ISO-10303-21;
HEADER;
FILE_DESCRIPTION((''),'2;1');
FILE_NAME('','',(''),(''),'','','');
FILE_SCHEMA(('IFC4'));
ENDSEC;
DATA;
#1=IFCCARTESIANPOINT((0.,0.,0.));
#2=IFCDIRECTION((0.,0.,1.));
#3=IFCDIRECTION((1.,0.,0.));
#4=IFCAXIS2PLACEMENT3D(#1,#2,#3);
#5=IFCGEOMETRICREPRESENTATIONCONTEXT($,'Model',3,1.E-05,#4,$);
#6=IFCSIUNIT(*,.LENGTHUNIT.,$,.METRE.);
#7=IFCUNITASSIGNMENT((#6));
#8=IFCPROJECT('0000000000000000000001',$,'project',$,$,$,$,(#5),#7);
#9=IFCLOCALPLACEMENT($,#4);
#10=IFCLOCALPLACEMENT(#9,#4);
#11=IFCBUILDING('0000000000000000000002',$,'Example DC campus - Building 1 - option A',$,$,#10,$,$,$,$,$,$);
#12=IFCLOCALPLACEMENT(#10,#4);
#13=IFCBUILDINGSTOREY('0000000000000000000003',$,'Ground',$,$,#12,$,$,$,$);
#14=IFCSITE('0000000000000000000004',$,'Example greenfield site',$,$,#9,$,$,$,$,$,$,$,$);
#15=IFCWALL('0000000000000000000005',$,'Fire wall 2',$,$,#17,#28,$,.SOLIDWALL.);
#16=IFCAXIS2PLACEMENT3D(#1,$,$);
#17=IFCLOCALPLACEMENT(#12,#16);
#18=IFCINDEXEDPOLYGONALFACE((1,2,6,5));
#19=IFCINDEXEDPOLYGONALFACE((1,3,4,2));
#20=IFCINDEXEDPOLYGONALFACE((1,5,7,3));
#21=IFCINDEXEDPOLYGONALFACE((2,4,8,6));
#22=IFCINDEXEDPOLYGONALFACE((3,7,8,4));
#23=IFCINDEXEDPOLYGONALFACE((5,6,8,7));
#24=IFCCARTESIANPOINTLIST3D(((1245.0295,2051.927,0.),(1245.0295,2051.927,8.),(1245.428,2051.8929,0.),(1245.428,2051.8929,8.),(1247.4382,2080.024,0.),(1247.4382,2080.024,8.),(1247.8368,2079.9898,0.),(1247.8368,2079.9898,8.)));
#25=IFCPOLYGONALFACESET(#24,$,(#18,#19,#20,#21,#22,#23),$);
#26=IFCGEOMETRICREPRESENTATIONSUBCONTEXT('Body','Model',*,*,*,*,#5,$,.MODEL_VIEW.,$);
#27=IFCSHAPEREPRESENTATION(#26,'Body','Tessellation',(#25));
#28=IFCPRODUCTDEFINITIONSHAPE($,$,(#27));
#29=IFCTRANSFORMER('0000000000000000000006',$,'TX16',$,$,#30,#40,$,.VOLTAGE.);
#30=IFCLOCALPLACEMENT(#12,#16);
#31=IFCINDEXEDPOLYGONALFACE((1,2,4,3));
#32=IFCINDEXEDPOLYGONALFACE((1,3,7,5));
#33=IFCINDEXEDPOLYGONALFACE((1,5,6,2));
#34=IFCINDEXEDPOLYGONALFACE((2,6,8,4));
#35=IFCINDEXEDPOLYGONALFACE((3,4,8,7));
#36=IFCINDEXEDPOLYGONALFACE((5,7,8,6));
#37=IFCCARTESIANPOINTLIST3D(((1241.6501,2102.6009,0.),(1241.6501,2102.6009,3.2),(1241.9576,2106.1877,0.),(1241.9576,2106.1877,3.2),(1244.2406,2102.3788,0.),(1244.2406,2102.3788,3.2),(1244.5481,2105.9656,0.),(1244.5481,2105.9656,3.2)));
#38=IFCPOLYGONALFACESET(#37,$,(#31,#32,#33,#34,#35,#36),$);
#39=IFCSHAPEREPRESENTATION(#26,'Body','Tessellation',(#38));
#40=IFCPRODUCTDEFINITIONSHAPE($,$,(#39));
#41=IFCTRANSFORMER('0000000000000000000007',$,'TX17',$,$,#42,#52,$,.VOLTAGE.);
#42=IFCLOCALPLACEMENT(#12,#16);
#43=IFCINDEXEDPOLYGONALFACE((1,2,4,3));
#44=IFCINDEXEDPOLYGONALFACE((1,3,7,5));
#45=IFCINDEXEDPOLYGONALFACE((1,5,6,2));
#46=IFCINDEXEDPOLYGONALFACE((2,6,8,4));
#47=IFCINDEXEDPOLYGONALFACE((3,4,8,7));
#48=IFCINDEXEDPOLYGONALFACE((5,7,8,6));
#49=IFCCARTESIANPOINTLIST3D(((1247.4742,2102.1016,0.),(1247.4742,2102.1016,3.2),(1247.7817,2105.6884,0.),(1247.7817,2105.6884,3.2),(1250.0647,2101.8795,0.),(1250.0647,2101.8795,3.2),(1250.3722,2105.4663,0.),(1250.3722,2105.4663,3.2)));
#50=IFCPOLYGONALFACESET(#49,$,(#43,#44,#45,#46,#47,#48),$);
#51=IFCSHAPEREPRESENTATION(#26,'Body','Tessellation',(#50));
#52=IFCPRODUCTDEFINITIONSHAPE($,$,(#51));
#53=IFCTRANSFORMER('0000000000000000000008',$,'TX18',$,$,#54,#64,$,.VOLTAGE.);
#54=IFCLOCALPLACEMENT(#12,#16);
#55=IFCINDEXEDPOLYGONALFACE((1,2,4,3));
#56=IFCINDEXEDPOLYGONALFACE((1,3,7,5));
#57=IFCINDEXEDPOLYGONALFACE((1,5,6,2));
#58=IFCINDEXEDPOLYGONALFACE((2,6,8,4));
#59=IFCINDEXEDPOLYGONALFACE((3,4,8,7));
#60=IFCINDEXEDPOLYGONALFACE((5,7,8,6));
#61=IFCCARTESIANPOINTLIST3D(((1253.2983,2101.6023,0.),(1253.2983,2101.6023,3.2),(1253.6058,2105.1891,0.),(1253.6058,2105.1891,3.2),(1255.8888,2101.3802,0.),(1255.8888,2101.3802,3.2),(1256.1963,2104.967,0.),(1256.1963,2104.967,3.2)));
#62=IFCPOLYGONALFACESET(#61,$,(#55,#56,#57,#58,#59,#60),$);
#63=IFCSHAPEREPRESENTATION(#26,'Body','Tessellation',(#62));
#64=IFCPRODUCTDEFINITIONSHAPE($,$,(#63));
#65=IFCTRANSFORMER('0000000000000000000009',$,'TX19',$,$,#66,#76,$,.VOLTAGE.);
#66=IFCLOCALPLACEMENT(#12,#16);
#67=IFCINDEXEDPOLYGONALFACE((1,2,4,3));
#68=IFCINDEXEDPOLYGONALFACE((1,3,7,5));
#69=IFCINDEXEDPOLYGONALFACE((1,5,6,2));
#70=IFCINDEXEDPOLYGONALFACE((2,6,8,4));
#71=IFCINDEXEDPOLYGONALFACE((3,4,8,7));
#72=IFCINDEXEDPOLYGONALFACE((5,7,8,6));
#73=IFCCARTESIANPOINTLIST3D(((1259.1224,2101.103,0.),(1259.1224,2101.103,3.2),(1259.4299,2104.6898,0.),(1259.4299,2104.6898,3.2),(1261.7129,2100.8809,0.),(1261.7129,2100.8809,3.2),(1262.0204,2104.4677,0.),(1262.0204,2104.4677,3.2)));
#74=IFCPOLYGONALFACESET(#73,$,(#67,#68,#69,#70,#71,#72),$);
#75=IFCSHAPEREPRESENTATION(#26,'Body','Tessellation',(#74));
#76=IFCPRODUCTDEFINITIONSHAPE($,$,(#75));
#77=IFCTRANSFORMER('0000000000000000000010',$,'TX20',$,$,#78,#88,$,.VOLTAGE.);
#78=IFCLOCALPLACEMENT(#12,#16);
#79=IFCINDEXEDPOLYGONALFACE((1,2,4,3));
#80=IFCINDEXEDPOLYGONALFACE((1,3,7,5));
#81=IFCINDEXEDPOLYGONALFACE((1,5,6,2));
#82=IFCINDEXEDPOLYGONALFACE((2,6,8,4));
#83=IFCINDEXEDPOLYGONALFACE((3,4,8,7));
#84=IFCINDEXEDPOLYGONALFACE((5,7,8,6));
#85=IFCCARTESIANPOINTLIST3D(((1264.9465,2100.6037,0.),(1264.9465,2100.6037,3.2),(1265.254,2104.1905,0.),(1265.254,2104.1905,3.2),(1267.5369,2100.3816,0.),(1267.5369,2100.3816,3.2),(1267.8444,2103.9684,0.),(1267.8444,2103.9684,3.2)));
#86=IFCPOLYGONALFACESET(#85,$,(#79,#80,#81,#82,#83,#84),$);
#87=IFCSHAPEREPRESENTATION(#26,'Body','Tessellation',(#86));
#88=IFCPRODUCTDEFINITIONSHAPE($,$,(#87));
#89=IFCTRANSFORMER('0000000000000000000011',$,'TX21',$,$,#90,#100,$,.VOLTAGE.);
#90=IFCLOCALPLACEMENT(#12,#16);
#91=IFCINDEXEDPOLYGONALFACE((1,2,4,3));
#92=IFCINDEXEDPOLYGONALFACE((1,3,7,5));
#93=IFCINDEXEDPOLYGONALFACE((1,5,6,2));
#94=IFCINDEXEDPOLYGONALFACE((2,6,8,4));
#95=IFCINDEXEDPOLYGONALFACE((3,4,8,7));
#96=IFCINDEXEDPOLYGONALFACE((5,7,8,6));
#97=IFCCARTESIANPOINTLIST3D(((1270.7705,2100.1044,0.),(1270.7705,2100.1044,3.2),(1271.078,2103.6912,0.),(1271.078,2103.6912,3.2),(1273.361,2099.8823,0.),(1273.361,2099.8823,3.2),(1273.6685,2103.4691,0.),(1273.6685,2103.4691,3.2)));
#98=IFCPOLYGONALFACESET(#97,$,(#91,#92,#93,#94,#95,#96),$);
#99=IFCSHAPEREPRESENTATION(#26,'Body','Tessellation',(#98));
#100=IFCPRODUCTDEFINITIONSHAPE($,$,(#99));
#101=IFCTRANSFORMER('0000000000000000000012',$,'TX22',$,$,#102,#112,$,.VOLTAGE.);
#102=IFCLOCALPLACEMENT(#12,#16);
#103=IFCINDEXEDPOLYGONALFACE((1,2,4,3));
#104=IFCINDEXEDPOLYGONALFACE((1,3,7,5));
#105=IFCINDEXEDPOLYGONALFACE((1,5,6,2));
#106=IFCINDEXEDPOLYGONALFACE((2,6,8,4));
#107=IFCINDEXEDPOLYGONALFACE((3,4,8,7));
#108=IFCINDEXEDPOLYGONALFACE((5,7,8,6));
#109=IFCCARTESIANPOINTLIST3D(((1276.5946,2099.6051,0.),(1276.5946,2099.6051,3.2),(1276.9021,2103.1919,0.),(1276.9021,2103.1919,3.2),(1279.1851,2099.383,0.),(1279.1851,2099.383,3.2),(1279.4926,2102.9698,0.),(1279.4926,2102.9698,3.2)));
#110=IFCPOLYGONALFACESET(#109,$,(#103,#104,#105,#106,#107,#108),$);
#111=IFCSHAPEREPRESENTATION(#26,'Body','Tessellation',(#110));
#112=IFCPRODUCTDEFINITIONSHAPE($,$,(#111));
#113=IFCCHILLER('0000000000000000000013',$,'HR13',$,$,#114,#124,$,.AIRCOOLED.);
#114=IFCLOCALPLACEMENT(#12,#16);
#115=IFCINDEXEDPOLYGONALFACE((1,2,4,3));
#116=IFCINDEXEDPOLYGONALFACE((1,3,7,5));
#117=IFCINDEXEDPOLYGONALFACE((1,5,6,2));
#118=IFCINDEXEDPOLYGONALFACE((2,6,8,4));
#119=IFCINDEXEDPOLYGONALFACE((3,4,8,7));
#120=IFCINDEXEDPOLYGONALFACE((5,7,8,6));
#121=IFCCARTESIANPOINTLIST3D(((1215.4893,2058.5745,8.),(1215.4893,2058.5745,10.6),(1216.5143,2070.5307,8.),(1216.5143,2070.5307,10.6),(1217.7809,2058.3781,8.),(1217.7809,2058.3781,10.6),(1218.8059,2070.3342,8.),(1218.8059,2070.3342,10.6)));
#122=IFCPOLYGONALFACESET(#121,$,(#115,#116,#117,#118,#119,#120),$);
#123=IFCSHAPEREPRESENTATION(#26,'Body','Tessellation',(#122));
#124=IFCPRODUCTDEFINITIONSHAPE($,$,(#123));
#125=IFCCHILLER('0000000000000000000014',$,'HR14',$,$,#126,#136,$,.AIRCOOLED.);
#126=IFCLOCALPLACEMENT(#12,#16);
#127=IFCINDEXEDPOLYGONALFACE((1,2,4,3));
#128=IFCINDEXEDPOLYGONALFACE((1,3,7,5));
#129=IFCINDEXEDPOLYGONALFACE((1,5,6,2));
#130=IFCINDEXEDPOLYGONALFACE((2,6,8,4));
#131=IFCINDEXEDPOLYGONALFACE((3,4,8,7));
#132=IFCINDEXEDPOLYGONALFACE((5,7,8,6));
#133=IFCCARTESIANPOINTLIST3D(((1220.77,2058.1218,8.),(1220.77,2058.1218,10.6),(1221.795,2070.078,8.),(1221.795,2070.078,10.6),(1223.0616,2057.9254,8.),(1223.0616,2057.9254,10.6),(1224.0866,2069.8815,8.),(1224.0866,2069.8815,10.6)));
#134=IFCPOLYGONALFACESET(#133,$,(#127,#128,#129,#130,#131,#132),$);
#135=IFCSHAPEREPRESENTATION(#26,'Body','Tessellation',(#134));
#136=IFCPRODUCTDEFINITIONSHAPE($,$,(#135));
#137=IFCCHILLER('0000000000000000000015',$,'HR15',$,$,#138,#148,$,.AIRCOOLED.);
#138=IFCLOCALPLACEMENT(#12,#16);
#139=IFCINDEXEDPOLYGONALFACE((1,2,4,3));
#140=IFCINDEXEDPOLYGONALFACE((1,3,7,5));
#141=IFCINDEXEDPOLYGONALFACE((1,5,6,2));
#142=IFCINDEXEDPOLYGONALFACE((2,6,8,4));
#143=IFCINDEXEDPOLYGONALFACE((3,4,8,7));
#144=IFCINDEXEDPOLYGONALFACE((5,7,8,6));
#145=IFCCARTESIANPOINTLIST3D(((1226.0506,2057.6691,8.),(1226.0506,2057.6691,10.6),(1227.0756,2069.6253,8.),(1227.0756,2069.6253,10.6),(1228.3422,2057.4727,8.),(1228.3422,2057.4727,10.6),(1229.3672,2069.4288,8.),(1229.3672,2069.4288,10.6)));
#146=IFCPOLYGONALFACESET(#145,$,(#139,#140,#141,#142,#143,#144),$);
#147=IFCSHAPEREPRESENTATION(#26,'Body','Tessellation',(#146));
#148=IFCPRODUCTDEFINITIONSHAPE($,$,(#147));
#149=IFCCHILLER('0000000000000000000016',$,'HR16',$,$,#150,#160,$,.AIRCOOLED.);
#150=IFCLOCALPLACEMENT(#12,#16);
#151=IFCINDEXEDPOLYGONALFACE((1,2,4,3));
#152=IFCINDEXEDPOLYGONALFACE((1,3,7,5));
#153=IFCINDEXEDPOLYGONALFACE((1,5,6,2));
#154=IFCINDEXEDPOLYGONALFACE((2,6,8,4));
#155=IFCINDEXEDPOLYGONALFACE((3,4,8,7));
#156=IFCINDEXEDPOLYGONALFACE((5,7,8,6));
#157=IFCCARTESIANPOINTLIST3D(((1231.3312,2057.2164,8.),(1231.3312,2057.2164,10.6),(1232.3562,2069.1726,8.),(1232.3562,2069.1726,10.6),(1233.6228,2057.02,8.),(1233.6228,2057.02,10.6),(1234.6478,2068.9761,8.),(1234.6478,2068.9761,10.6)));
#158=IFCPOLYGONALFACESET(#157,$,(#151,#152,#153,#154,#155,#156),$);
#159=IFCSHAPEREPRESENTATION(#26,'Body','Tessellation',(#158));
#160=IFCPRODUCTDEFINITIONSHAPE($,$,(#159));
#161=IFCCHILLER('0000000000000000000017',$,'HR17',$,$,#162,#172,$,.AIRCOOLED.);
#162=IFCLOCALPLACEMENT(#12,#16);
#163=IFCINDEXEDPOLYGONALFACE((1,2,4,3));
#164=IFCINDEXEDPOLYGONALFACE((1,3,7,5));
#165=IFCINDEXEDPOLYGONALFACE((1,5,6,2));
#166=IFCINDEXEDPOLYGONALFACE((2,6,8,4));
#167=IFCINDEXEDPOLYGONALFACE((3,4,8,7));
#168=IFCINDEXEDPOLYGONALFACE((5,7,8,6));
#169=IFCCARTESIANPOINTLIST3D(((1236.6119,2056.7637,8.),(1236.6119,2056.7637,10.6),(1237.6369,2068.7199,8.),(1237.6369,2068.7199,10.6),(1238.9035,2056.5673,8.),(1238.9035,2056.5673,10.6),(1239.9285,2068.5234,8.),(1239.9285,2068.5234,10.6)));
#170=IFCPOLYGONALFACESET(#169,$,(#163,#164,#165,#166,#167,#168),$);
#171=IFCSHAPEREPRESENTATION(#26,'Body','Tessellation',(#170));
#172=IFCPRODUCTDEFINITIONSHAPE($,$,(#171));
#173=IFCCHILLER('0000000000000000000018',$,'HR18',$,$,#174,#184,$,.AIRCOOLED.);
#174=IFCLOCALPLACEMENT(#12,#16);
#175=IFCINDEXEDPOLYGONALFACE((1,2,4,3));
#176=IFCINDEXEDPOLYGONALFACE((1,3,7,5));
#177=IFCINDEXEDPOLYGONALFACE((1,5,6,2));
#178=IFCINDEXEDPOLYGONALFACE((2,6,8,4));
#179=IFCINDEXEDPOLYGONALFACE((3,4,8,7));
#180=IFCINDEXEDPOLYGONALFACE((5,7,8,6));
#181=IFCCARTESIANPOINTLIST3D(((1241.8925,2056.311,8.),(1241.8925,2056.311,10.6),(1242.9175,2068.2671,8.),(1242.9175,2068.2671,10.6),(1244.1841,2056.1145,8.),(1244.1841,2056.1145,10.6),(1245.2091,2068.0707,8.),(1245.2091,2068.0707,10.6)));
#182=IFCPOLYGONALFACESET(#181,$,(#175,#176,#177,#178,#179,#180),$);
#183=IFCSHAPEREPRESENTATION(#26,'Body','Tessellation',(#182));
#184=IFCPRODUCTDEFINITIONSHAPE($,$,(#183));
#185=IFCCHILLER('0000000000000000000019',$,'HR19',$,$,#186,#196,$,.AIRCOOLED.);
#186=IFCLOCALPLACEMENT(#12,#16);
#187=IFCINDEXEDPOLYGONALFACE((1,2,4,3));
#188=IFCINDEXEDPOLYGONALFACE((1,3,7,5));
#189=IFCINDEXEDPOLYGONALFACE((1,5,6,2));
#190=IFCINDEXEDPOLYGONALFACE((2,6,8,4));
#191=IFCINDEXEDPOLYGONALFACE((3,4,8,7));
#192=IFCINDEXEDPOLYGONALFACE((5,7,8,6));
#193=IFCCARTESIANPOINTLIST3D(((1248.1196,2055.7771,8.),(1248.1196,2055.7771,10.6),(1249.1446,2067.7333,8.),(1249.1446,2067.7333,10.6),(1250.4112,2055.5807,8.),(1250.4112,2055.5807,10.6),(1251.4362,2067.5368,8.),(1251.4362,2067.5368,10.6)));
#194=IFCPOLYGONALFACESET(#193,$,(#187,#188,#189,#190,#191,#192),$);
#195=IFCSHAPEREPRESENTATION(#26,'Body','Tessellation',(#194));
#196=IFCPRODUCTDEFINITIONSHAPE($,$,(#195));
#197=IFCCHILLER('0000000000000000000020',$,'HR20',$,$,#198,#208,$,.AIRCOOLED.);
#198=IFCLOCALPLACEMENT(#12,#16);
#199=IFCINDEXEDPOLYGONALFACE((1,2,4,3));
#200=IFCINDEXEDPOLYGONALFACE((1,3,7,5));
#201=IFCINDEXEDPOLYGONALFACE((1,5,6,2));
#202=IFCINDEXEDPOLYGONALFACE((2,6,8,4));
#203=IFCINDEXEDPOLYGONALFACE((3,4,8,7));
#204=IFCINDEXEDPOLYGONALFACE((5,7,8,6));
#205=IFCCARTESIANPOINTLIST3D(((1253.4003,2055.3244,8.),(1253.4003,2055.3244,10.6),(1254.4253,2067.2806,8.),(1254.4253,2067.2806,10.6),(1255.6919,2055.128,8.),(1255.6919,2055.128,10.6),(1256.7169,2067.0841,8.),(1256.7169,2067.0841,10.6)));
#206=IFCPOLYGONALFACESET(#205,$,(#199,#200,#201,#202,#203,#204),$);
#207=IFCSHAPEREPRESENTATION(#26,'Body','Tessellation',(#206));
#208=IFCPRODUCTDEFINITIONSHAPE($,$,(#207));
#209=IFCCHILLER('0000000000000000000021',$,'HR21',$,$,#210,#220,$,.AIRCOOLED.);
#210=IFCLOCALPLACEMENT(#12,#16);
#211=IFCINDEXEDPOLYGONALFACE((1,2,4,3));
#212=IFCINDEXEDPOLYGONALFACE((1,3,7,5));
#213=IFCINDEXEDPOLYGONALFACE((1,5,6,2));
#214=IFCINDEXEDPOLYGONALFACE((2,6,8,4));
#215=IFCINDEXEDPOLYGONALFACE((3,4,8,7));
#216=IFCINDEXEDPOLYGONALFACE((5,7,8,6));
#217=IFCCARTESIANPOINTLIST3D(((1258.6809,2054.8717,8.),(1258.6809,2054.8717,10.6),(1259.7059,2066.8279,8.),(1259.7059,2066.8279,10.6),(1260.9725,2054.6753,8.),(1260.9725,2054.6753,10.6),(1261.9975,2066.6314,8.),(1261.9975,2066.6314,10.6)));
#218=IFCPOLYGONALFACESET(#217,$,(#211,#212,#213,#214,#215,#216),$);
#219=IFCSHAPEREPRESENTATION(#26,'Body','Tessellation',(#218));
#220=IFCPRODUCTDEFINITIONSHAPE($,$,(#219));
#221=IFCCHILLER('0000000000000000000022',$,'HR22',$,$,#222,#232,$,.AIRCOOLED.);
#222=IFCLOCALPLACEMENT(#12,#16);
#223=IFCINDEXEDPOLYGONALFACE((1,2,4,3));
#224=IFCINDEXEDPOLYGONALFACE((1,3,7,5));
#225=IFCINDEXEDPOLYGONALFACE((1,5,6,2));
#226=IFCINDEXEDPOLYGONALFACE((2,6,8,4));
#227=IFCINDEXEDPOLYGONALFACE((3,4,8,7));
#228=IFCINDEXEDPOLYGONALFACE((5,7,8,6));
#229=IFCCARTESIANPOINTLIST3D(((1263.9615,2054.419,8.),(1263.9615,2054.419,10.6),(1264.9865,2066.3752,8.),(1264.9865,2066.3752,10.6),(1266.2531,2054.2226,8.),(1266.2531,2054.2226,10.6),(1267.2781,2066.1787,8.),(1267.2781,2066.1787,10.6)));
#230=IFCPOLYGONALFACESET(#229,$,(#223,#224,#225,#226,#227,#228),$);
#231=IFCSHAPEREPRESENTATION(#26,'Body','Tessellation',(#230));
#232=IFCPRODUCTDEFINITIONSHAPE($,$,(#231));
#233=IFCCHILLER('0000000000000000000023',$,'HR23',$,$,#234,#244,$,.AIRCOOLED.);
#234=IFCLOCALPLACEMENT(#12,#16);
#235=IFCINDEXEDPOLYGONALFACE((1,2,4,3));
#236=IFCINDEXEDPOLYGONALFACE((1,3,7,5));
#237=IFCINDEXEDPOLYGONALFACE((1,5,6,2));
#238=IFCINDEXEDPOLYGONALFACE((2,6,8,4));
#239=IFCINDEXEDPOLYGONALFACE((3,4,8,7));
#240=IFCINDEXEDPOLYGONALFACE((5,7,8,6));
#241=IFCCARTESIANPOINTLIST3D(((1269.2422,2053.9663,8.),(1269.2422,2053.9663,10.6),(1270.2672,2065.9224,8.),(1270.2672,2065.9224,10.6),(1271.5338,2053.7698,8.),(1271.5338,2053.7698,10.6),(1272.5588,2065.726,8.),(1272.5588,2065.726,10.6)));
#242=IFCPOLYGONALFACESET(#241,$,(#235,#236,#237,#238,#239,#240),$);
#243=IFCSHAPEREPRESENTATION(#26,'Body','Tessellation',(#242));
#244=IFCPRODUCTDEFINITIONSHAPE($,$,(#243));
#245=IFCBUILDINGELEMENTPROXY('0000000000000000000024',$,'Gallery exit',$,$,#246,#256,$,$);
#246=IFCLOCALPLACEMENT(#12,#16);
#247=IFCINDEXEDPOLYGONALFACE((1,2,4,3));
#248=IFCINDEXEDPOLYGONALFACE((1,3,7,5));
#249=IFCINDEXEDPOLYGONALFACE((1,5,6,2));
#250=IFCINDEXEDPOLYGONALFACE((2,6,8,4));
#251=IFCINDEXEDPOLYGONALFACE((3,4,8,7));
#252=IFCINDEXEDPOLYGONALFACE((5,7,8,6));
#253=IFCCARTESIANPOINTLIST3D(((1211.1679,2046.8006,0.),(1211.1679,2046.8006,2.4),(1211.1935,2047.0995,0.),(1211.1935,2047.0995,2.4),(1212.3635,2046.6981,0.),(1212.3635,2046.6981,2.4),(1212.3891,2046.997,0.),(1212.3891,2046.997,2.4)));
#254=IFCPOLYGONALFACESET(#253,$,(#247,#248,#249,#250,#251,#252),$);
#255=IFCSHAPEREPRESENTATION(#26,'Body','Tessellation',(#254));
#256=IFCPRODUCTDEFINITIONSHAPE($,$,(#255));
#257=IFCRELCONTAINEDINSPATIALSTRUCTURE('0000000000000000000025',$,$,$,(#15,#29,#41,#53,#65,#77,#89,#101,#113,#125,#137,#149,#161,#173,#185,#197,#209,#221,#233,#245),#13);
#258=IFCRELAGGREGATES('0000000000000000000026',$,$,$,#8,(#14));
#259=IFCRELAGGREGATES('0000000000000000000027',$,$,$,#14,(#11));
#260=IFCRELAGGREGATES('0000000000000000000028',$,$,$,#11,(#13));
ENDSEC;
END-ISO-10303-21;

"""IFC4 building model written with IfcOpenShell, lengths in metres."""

from ifc_helpers import new_model, si_unit, frame, origin_with_axes, place, context, subcontext, project, spatial, line, indexed_curve, outline, extrude, element, save


model = new_model("IFC4")

# Units and contexts
model_context = context("Model", 3, precision=1e-05, world=origin_with_axes())
body_context = subcontext(model_context, "Body", "Model", "MODEL_VIEW")
ifc_project = project(units=[si_unit("LENGTHUNIT", "METRE")], contexts=[model_context])

# Site, building, storey
site_placement = place(None, origin_with_axes())
site = spatial("IfcSite", under=ifc_project, at=site_placement, Name="Example greenfield site")
building_placement = place(site_placement, origin_with_axes())
building = spatial("IfcBuilding", under=site, at=building_placement, Name="Example DC campus - Building 1 - option A")
storey_placement = place(building_placement, origin_with_axes())
storey = spatial("IfcBuildingStorey", under=building, at=storey_placement, Name="Ground")

# Wall
wall_placement = place(storey_placement, frame((1245.0295, 2051.927, 0.0), z_axis=(0.0, 0.0, 1.0), x_axis=(0.996345, -0.085417, 0.0)))
element("IfcWall", 1, at=wall_placement, inside=storey, Name="Fire wall 2", PredefinedType="SOLIDWALL", context=body_context, shape_type="SweptSolid", body=[
    extrude(outline(indexed_curve([(0.0, 0.0), (0.4, 0.0), (0.4, 28.2), (0.0, 28.2)], segments=[line(1, 2, 3, 4, 1)])), origin_with_axes(), (0.0, 0.0, 1.0), 8.0),
])

# Transformers
for number, where, z_axis, x_axis, name in (
    (2, (1241.6501, 2102.6009, 0.0), (0.0, 0.0, 1.0), (0.996345, -0.085417, 0.0), "TX16"),
    (3, (1247.4742, 2102.1016, 0.0), (0.0, 0.0, 1.0), (0.996345, -0.085417, 0.0), "TX17"),
    (4, (1253.2983, 2101.6023, 0.0), (0.0, 0.0, 1.0), (0.996345, -0.085417, 0.0), "TX18"),
    (5, (1259.1224, 2101.103, 0.0), (0.0, 0.0, 1.0), (0.996345, -0.085417, 0.0), "TX19"),
    (6, (1264.9465, 2100.6037, 0.0), (0.0, 0.0, 1.0), (0.996345, -0.085417, 0.0), "TX20"),
    (7, (1270.7705, 2100.1044, 0.0), (0.0, 0.0, 1.0), (0.996345, -0.085417, 0.0), "TX21"),
    (8, (1276.5946, 2099.6051, 0.0), (0.0, 0.0, 1.0), (0.996345, -0.085417, 0.0), "TX22"),
):
    element("IfcTransformer", number, at=place(storey_placement, frame(where, z_axis=z_axis, x_axis=x_axis)), inside=storey, Name=name, PredefinedType="VOLTAGE", context=body_context, shape_type="SweptSolid", body=[
        extrude(outline(indexed_curve([(0.0, 0.0), (2.6, 0.0), (2.6, 3.6), (0.0, 3.6)], segments=[line(1, 2, 3, 4, 1)])), origin_with_axes(), (0.0, 0.0, 1.0), 3.2),
    ])

# Chillers
for number, where, z_axis, x_axis, name in (
    (9, (1215.4893, 2058.5745, 8.0), (0.0, 0.0, 1.0), (0.996345, -0.085417, 0.0), "HR13"),
    (10, (1220.77, 2058.1218, 8.0), (0.0, 0.0, 1.0), (0.996345, -0.085417, 0.0), "HR14"),
    (11, (1226.0506, 2057.6691, 8.0), (0.0, 0.0, 1.0), (0.996345, -0.085417, 0.0), "HR15"),
    (12, (1231.3312, 2057.2164, 8.0), (0.0, 0.0, 1.0), (0.996345, -0.085417, 0.0), "HR16"),
    (13, (1236.6119, 2056.7637, 8.0), (0.0, 0.0, 1.0), (0.996345, -0.085417, 0.0), "HR17"),
    (14, (1241.8925, 2056.311, 8.0), (0.0, 0.0, 1.0), (0.996345, -0.085417, 0.0), "HR18"),
    (15, (1248.1196, 2055.7771, 8.0), (0.0, 0.0, 1.0), (0.996345, -0.085417, 0.0), "HR19"),
    (16, (1253.4003, 2055.3244, 8.0), (0.0, 0.0, 1.0), (0.996345, -0.085417, 0.0), "HR20"),
    (17, (1258.6809, 2054.8717, 8.0), (0.0, 0.0, 1.0), (0.996345, -0.085417, 0.0), "HR21"),
    (18, (1263.9615, 2054.419, 8.0), (0.0, 0.0, 1.0), (0.996345, -0.085417, 0.0), "HR22"),
    (19, (1269.2422, 2053.9663, 8.0), (0.0, 0.0, 1.0), (0.996345, -0.085417, 0.0), "HR23"),
):
    element("IfcChiller", number, at=place(storey_placement, frame(where, z_axis=z_axis, x_axis=x_axis)), inside=storey, Name=name, PredefinedType="AIRCOOLED", context=body_context, shape_type="SweptSolid", body=[
        extrude(outline(indexed_curve([(0.0, 0.0), (2.3, 0.0), (2.3, 12.0), (0.0, 12.0)], segments=[line(1, 2, 3, 4, 1)])), origin_with_axes(), (0.0, 0.0, 1.0), 2.6),
    ])

# Building element proxy
for number, where, z_axis, x_axis, name in (
    (20, (1211.1679, 2046.8006, 0.0), (0.0, 0.0, 1.0), (0.996345, -0.085417, 0.0), "Gallery exit"),
):
    element("IfcBuildingElementProxy", number, at=place(storey_placement, frame(where, z_axis=z_axis, x_axis=x_axis)), inside=storey, Name=name, context=body_context, shape_type="SweptSolid", body=[
        extrude(outline(indexed_curve([(0.0, 0.0), (1.2, 0.0), (1.2, 0.3), (0.0, 0.3)], segments=[line(1, 2, 3, 4, 1)])), origin_with_axes(), (0.0, 0.0, 1.0), 2.4),
    ])

save(model, "model.ifc")
